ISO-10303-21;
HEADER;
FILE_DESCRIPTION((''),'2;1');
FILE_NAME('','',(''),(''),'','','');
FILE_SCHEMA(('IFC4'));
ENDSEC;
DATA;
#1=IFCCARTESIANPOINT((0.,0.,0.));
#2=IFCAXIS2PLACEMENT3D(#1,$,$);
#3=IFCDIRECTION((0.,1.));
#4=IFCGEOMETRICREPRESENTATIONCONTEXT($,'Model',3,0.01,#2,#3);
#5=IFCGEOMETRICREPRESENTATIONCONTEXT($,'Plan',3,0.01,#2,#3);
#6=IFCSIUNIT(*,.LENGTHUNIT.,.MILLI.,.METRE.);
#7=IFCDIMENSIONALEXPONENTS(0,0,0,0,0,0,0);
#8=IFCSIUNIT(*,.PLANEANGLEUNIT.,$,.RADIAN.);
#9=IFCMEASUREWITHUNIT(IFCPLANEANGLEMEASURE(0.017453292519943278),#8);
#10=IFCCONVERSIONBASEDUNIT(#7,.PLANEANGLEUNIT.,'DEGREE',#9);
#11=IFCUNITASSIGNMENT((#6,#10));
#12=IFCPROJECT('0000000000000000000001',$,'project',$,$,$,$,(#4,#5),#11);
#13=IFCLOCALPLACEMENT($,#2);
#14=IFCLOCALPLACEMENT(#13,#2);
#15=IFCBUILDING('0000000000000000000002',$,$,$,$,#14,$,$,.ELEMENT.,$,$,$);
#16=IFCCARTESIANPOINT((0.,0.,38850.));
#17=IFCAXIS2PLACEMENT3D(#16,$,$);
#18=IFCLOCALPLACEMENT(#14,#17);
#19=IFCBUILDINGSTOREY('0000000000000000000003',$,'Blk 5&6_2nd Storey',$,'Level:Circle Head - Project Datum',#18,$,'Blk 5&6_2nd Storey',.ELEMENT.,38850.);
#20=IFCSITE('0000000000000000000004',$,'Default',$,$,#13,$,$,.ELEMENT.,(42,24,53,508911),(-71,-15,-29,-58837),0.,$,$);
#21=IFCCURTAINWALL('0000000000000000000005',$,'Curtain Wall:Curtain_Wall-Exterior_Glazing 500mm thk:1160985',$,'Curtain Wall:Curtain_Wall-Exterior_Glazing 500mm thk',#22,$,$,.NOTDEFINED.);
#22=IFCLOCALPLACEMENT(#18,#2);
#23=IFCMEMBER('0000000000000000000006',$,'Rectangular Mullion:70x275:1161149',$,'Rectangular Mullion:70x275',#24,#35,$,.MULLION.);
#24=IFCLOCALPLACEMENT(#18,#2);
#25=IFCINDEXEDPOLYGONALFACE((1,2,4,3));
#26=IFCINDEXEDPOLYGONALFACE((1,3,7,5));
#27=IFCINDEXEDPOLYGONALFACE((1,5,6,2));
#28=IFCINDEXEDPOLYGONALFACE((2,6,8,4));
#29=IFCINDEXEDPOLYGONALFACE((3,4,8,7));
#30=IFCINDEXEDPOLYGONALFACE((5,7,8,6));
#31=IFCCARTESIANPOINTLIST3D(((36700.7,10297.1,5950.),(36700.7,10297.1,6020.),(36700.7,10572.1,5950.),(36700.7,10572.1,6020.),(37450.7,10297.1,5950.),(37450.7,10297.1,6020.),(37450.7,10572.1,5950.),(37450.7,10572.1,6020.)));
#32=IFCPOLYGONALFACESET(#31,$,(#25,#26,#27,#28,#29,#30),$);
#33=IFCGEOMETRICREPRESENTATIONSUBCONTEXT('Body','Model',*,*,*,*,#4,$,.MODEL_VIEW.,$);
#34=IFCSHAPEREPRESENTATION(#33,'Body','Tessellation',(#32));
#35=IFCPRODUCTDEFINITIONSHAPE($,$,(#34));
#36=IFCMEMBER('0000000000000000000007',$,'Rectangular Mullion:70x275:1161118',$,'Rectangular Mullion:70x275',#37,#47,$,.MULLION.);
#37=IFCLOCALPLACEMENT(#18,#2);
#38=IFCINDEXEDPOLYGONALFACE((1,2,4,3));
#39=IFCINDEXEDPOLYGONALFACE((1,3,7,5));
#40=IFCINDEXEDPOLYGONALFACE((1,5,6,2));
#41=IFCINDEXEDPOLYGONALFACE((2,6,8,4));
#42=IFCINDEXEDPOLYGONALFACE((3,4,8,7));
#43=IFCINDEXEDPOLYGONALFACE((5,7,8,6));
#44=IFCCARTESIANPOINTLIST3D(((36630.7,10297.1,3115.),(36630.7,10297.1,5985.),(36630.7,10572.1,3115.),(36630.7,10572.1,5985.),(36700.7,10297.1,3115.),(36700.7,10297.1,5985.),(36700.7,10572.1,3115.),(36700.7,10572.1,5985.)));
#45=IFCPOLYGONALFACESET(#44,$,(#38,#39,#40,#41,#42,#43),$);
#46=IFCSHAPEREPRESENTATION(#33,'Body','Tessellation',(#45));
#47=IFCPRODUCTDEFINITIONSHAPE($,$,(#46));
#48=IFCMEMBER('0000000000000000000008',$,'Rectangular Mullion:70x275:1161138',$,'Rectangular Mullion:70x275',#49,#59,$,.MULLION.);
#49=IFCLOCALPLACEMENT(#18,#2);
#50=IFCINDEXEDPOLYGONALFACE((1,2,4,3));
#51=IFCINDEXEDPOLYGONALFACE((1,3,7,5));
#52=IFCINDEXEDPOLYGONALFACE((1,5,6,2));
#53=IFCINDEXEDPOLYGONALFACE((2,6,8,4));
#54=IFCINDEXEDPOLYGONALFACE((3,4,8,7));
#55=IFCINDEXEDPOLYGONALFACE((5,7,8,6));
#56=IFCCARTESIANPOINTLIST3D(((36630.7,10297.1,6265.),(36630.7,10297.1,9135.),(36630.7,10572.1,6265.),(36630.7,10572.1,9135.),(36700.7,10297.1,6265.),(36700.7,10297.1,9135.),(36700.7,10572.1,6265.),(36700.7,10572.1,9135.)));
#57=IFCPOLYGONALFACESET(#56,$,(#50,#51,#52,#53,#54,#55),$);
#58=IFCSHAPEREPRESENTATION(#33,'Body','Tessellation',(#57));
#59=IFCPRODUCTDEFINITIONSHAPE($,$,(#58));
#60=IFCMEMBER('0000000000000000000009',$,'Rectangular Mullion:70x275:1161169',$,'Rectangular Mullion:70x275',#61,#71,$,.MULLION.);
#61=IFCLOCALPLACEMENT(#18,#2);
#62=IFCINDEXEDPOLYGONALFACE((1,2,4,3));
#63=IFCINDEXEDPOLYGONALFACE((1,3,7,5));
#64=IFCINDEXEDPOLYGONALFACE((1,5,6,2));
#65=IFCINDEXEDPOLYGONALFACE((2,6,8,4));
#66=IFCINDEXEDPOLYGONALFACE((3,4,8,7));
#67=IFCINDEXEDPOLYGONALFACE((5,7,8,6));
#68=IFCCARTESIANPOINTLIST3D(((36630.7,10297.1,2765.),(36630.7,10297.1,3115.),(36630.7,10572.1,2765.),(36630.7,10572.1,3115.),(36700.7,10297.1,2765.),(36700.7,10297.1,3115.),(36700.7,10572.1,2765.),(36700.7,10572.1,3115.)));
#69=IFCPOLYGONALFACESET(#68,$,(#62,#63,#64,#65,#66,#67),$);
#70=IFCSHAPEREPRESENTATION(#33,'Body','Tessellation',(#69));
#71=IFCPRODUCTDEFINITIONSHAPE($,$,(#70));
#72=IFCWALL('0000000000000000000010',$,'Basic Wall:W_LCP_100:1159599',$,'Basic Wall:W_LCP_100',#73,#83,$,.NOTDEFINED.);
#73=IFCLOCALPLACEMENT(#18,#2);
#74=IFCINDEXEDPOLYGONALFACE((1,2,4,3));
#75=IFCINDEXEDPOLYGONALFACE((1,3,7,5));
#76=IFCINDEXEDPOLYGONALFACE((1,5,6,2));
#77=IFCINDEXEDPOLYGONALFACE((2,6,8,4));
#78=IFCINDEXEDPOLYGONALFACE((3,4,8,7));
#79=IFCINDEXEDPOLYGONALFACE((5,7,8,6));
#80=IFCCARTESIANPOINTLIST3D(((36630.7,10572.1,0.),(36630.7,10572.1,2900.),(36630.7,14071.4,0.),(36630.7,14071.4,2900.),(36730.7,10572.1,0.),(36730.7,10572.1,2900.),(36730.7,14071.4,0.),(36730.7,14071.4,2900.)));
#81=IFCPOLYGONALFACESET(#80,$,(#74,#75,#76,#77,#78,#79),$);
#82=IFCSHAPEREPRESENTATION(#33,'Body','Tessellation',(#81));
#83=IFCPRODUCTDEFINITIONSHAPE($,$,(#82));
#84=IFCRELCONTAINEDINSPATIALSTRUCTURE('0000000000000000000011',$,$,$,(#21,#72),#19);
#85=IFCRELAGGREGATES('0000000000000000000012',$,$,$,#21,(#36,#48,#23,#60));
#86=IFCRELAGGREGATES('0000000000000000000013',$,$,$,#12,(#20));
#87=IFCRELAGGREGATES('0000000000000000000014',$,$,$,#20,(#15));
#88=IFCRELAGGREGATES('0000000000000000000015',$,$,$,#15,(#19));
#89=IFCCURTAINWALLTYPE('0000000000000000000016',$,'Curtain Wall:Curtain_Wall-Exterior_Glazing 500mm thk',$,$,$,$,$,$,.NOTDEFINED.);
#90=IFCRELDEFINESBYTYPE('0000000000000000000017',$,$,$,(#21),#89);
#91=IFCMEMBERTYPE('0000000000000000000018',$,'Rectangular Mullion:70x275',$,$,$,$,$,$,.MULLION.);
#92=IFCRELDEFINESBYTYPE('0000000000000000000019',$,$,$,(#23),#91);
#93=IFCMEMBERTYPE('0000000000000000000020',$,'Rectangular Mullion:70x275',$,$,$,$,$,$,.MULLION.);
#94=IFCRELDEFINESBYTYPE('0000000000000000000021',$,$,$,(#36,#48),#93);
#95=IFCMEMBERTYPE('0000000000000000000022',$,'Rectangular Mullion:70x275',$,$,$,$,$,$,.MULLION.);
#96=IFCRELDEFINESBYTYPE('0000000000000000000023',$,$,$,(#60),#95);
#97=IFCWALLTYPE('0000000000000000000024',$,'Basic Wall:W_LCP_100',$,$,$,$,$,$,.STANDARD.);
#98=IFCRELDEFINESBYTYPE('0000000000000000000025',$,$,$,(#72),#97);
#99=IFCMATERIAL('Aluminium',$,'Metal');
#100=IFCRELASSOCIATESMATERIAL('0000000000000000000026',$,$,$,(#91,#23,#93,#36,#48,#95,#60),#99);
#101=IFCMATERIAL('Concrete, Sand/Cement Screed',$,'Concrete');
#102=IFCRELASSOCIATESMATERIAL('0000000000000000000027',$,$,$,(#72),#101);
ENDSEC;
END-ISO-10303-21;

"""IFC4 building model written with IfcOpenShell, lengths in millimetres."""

from ifc_helpers import new_model, entity, si_unit, converted_unit, direction, frame, origin, place, context, subcontext, project, spatial, indexed_curve, outline, extrude, source, transform, mapped, material, type_object, type_shapes, element, aggregate, save


model = new_model("IFC4")

# Units and contexts
model_context = context("Model", 3, precision=0.01, world=origin(), true_north=direction((0.0, 1.0)))
plan_context = context("Plan", 3, precision=0.01, world=origin(), true_north=direction((0.0, 1.0)))
body_context = subcontext(model_context, "Body", "Model", "MODEL_VIEW")
ifc_project = project(units=[si_unit("LENGTHUNIT", "METRE", prefix="MILLI"), converted_unit("PLANEANGLEUNIT", "DEGREE", entity("IfcPlaneAngleMeasure", 0.017453292519943278), si_unit("PLANEANGLEUNIT", "RADIAN"), dimensions=[0, 0, 0, 0, 0, 0, 0])], contexts=[model_context, plan_context])

# Site, building, storey
site_placement = place(None, origin())
site = spatial("IfcSite", under=ifc_project, at=site_placement, Name="Default", CompositionType="ELEMENT", RefLatitude=(42, 24, 53, 508911), RefLongitude=(-71, -15, -29, -58837), RefElevation=0.0)
building_placement = place(site_placement, origin())
building = spatial("IfcBuilding", under=site, at=building_placement, CompositionType="ELEMENT")
storey_placement = place(building_placement, frame((0.0, 0.0, 38850.0)))
storey = spatial("IfcBuildingStorey", under=building, at=storey_placement, Name="Blk 5&6_2nd Storey", ObjectType="Level:Circle Head - Project Datum", LongName="Blk 5&6_2nd Storey", CompositionType="ELEMENT", Elevation=38850.0)

# Curtain wall, members
curtain_wall_type = type_object("IfcCurtainWallType", Name="Curtain Wall:Curtain_Wall-Exterior_Glazing 500mm thk", PredefinedType="NOTDEFINED")
curtain_wall_placement = place(storey_placement, frame((0.0, 0.0, -38850.0)))
curtain_wall = element("IfcCurtainWall", 1, at=curtain_wall_placement, inside=storey, type_object=curtain_wall_type, Name="Curtain Wall:Curtain_Wall-Exterior_Glazing 500mm thk:1160985", ObjectType="Curtain Wall:Curtain_Wall-Exterior_Glazing 500mm thk", PredefinedType="NOTDEFINED")
ifc_material_1 = material(Name="Aluminium", Category="Metal")
member_type_1 = type_object("IfcMemberType", Name="Rectangular Mullion:70x275", PredefinedType="MULLION", material=ifc_material_1)
shared_shape_1 = source(origin(), body_context, "Body", "SweptSolid", [
    extrude(outline(indexed_curve([(-35.0, -137.5), (35.0, -137.5), (35.0, 137.5), (-35.0, 137.5), (-35.0, -137.5)], self_intersect=False)), frame((0.0, -137.5, -750.0), z_axis=(0.0, 0.0, 1.0), x_axis=(-1.0, 0.0, 0.0)), (0.0, 0.0, 1.0), 750.0),
])
type_shapes(member_type_1, [shared_shape_1])
member_1_placement = place(curtain_wall_placement, frame((36700.7, 10572.1, 44835.0), z_axis=(-1.0, 0.0, 0.0), x_axis=(0.0, 0.0, 1.0)))
member_1 = element("IfcMember", 2, at=member_1_placement, type_object=member_type_1, material=ifc_material_1, Name="Rectangular Mullion:70x275:1161149", ObjectType="Rectangular Mullion:70x275", PredefinedType="MULLION", context=body_context, shape_type="MappedRepresentation", body=[
    mapped(shared_shape_1, transform((0.0, 0.0, 0.0), scale=1.0)),
])
member_type_2 = type_object("IfcMemberType", Name="Rectangular Mullion:70x275", PredefinedType="MULLION", material=ifc_material_1)
shared_shape_2 = source(origin(), body_context, "Body", "SweptSolid", [
    extrude(outline(indexed_curve([(-35.0, -137.5), (35.0, -137.5), (35.0, 137.5), (-35.0, 137.5), (-35.0, -137.5)], self_intersect=False)), frame((-35.0, -137.5, -2870.0), z_axis=(0.0, 0.0, 1.0), x_axis=(-1.0, 0.0, 0.0)), (0.0, 0.0, 1.0), 2870.0),
])
type_shapes(member_type_2, [shared_shape_2])
member_2_placement = place(curtain_wall_placement, frame((36630.7, 10572.1, 41965.0), z_axis=(0.0, 0.0, -1.0), x_axis=(-1.0, 0.0, 0.0)))
member_2 = element("IfcMember", 3, at=member_2_placement, type_object=member_type_2, material=ifc_material_1, Name="Rectangular Mullion:70x275:1161118", ObjectType="Rectangular Mullion:70x275", PredefinedType="MULLION", context=body_context, shape_type="MappedRepresentation", body=[
    mapped(shared_shape_2, transform((0.0, 0.0, 0.0), scale=1.0)),
])
member_3_placement = place(curtain_wall_placement, frame((36630.7, 10572.1, 45115.0), z_axis=(0.0, 0.0, -1.0), x_axis=(-1.0, 0.0, 0.0)))
member_3 = element("IfcMember", 4, at=member_3_placement, type_object=member_type_2, material=ifc_material_1, Name="Rectangular Mullion:70x275:1161138", ObjectType="Rectangular Mullion:70x275", PredefinedType="MULLION", context=body_context, shape_type="MappedRepresentation", body=[
    mapped(shared_shape_2, transform((0.0, 0.0, 0.0), scale=1.0)),
])
member_type_3 = type_object("IfcMemberType", Name="Rectangular Mullion:70x275", PredefinedType="MULLION", material=ifc_material_1)
shared_shape_3 = source(origin(), body_context, "Body", "SweptSolid", [
    extrude(outline(indexed_curve([(-35.0, -137.5), (35.0, -137.5), (35.0, 137.5), (-35.0, 137.5), (-35.0, -137.5)], self_intersect=False)), frame((-35.0, -137.5, -350.0), z_axis=(0.0, 0.0, 1.0), x_axis=(-1.0, 0.0, 0.0)), (0.0, 0.0, 1.0), 350.0),
])
type_shapes(member_type_3, [shared_shape_3])
member_4_placement = place(curtain_wall_placement, frame((36630.7, 10572.1, 41615.0), z_axis=(0.0, 0.0, -1.0), x_axis=(-1.0, 0.0, 0.0)))
member_4 = element("IfcMember", 5, at=member_4_placement, type_object=member_type_3, material=ifc_material_1, Name="Rectangular Mullion:70x275:1161169", ObjectType="Rectangular Mullion:70x275", PredefinedType="MULLION", context=body_context, shape_type="MappedRepresentation", body=[
    mapped(shared_shape_3, transform((0.0, 0.0, 0.0), scale=1.0)),
])
aggregate(curtain_wall, [member_2, member_3, member_1, member_4])

# Wall
ifc_material_2 = material(Name="Concrete, Sand/Cement Screed", Category="Concrete")
wall_type = type_object("IfcWallType", Name="Basic Wall:W_LCP_100", PredefinedType="STANDARD")
wall_placement = place(storey_placement, frame((36680.7, 10572.1, 0.0), z_axis=(0.0, 0.0, 1.0), x_axis=(0.0, 1.0, 0.0)))
element("IfcWall", 6, at=wall_placement, inside=storey, type_object=wall_type, material=ifc_material_2, Name="Basic Wall:W_LCP_100:1159599", ObjectType="Basic Wall:W_LCP_100", PredefinedType="NOTDEFINED", context=body_context, shape_type="SweptSolid", body=[
    extrude(outline(indexed_curve([(3499.3, 50.0), (0.0, 50.0), (0.0, -50.0), (3499.3, -50.0), (3499.3, 50.0)], self_intersect=False)), origin(), (0.0, 0.0, 1.0), 2900.0),
])

save(model, "model.ifc")
